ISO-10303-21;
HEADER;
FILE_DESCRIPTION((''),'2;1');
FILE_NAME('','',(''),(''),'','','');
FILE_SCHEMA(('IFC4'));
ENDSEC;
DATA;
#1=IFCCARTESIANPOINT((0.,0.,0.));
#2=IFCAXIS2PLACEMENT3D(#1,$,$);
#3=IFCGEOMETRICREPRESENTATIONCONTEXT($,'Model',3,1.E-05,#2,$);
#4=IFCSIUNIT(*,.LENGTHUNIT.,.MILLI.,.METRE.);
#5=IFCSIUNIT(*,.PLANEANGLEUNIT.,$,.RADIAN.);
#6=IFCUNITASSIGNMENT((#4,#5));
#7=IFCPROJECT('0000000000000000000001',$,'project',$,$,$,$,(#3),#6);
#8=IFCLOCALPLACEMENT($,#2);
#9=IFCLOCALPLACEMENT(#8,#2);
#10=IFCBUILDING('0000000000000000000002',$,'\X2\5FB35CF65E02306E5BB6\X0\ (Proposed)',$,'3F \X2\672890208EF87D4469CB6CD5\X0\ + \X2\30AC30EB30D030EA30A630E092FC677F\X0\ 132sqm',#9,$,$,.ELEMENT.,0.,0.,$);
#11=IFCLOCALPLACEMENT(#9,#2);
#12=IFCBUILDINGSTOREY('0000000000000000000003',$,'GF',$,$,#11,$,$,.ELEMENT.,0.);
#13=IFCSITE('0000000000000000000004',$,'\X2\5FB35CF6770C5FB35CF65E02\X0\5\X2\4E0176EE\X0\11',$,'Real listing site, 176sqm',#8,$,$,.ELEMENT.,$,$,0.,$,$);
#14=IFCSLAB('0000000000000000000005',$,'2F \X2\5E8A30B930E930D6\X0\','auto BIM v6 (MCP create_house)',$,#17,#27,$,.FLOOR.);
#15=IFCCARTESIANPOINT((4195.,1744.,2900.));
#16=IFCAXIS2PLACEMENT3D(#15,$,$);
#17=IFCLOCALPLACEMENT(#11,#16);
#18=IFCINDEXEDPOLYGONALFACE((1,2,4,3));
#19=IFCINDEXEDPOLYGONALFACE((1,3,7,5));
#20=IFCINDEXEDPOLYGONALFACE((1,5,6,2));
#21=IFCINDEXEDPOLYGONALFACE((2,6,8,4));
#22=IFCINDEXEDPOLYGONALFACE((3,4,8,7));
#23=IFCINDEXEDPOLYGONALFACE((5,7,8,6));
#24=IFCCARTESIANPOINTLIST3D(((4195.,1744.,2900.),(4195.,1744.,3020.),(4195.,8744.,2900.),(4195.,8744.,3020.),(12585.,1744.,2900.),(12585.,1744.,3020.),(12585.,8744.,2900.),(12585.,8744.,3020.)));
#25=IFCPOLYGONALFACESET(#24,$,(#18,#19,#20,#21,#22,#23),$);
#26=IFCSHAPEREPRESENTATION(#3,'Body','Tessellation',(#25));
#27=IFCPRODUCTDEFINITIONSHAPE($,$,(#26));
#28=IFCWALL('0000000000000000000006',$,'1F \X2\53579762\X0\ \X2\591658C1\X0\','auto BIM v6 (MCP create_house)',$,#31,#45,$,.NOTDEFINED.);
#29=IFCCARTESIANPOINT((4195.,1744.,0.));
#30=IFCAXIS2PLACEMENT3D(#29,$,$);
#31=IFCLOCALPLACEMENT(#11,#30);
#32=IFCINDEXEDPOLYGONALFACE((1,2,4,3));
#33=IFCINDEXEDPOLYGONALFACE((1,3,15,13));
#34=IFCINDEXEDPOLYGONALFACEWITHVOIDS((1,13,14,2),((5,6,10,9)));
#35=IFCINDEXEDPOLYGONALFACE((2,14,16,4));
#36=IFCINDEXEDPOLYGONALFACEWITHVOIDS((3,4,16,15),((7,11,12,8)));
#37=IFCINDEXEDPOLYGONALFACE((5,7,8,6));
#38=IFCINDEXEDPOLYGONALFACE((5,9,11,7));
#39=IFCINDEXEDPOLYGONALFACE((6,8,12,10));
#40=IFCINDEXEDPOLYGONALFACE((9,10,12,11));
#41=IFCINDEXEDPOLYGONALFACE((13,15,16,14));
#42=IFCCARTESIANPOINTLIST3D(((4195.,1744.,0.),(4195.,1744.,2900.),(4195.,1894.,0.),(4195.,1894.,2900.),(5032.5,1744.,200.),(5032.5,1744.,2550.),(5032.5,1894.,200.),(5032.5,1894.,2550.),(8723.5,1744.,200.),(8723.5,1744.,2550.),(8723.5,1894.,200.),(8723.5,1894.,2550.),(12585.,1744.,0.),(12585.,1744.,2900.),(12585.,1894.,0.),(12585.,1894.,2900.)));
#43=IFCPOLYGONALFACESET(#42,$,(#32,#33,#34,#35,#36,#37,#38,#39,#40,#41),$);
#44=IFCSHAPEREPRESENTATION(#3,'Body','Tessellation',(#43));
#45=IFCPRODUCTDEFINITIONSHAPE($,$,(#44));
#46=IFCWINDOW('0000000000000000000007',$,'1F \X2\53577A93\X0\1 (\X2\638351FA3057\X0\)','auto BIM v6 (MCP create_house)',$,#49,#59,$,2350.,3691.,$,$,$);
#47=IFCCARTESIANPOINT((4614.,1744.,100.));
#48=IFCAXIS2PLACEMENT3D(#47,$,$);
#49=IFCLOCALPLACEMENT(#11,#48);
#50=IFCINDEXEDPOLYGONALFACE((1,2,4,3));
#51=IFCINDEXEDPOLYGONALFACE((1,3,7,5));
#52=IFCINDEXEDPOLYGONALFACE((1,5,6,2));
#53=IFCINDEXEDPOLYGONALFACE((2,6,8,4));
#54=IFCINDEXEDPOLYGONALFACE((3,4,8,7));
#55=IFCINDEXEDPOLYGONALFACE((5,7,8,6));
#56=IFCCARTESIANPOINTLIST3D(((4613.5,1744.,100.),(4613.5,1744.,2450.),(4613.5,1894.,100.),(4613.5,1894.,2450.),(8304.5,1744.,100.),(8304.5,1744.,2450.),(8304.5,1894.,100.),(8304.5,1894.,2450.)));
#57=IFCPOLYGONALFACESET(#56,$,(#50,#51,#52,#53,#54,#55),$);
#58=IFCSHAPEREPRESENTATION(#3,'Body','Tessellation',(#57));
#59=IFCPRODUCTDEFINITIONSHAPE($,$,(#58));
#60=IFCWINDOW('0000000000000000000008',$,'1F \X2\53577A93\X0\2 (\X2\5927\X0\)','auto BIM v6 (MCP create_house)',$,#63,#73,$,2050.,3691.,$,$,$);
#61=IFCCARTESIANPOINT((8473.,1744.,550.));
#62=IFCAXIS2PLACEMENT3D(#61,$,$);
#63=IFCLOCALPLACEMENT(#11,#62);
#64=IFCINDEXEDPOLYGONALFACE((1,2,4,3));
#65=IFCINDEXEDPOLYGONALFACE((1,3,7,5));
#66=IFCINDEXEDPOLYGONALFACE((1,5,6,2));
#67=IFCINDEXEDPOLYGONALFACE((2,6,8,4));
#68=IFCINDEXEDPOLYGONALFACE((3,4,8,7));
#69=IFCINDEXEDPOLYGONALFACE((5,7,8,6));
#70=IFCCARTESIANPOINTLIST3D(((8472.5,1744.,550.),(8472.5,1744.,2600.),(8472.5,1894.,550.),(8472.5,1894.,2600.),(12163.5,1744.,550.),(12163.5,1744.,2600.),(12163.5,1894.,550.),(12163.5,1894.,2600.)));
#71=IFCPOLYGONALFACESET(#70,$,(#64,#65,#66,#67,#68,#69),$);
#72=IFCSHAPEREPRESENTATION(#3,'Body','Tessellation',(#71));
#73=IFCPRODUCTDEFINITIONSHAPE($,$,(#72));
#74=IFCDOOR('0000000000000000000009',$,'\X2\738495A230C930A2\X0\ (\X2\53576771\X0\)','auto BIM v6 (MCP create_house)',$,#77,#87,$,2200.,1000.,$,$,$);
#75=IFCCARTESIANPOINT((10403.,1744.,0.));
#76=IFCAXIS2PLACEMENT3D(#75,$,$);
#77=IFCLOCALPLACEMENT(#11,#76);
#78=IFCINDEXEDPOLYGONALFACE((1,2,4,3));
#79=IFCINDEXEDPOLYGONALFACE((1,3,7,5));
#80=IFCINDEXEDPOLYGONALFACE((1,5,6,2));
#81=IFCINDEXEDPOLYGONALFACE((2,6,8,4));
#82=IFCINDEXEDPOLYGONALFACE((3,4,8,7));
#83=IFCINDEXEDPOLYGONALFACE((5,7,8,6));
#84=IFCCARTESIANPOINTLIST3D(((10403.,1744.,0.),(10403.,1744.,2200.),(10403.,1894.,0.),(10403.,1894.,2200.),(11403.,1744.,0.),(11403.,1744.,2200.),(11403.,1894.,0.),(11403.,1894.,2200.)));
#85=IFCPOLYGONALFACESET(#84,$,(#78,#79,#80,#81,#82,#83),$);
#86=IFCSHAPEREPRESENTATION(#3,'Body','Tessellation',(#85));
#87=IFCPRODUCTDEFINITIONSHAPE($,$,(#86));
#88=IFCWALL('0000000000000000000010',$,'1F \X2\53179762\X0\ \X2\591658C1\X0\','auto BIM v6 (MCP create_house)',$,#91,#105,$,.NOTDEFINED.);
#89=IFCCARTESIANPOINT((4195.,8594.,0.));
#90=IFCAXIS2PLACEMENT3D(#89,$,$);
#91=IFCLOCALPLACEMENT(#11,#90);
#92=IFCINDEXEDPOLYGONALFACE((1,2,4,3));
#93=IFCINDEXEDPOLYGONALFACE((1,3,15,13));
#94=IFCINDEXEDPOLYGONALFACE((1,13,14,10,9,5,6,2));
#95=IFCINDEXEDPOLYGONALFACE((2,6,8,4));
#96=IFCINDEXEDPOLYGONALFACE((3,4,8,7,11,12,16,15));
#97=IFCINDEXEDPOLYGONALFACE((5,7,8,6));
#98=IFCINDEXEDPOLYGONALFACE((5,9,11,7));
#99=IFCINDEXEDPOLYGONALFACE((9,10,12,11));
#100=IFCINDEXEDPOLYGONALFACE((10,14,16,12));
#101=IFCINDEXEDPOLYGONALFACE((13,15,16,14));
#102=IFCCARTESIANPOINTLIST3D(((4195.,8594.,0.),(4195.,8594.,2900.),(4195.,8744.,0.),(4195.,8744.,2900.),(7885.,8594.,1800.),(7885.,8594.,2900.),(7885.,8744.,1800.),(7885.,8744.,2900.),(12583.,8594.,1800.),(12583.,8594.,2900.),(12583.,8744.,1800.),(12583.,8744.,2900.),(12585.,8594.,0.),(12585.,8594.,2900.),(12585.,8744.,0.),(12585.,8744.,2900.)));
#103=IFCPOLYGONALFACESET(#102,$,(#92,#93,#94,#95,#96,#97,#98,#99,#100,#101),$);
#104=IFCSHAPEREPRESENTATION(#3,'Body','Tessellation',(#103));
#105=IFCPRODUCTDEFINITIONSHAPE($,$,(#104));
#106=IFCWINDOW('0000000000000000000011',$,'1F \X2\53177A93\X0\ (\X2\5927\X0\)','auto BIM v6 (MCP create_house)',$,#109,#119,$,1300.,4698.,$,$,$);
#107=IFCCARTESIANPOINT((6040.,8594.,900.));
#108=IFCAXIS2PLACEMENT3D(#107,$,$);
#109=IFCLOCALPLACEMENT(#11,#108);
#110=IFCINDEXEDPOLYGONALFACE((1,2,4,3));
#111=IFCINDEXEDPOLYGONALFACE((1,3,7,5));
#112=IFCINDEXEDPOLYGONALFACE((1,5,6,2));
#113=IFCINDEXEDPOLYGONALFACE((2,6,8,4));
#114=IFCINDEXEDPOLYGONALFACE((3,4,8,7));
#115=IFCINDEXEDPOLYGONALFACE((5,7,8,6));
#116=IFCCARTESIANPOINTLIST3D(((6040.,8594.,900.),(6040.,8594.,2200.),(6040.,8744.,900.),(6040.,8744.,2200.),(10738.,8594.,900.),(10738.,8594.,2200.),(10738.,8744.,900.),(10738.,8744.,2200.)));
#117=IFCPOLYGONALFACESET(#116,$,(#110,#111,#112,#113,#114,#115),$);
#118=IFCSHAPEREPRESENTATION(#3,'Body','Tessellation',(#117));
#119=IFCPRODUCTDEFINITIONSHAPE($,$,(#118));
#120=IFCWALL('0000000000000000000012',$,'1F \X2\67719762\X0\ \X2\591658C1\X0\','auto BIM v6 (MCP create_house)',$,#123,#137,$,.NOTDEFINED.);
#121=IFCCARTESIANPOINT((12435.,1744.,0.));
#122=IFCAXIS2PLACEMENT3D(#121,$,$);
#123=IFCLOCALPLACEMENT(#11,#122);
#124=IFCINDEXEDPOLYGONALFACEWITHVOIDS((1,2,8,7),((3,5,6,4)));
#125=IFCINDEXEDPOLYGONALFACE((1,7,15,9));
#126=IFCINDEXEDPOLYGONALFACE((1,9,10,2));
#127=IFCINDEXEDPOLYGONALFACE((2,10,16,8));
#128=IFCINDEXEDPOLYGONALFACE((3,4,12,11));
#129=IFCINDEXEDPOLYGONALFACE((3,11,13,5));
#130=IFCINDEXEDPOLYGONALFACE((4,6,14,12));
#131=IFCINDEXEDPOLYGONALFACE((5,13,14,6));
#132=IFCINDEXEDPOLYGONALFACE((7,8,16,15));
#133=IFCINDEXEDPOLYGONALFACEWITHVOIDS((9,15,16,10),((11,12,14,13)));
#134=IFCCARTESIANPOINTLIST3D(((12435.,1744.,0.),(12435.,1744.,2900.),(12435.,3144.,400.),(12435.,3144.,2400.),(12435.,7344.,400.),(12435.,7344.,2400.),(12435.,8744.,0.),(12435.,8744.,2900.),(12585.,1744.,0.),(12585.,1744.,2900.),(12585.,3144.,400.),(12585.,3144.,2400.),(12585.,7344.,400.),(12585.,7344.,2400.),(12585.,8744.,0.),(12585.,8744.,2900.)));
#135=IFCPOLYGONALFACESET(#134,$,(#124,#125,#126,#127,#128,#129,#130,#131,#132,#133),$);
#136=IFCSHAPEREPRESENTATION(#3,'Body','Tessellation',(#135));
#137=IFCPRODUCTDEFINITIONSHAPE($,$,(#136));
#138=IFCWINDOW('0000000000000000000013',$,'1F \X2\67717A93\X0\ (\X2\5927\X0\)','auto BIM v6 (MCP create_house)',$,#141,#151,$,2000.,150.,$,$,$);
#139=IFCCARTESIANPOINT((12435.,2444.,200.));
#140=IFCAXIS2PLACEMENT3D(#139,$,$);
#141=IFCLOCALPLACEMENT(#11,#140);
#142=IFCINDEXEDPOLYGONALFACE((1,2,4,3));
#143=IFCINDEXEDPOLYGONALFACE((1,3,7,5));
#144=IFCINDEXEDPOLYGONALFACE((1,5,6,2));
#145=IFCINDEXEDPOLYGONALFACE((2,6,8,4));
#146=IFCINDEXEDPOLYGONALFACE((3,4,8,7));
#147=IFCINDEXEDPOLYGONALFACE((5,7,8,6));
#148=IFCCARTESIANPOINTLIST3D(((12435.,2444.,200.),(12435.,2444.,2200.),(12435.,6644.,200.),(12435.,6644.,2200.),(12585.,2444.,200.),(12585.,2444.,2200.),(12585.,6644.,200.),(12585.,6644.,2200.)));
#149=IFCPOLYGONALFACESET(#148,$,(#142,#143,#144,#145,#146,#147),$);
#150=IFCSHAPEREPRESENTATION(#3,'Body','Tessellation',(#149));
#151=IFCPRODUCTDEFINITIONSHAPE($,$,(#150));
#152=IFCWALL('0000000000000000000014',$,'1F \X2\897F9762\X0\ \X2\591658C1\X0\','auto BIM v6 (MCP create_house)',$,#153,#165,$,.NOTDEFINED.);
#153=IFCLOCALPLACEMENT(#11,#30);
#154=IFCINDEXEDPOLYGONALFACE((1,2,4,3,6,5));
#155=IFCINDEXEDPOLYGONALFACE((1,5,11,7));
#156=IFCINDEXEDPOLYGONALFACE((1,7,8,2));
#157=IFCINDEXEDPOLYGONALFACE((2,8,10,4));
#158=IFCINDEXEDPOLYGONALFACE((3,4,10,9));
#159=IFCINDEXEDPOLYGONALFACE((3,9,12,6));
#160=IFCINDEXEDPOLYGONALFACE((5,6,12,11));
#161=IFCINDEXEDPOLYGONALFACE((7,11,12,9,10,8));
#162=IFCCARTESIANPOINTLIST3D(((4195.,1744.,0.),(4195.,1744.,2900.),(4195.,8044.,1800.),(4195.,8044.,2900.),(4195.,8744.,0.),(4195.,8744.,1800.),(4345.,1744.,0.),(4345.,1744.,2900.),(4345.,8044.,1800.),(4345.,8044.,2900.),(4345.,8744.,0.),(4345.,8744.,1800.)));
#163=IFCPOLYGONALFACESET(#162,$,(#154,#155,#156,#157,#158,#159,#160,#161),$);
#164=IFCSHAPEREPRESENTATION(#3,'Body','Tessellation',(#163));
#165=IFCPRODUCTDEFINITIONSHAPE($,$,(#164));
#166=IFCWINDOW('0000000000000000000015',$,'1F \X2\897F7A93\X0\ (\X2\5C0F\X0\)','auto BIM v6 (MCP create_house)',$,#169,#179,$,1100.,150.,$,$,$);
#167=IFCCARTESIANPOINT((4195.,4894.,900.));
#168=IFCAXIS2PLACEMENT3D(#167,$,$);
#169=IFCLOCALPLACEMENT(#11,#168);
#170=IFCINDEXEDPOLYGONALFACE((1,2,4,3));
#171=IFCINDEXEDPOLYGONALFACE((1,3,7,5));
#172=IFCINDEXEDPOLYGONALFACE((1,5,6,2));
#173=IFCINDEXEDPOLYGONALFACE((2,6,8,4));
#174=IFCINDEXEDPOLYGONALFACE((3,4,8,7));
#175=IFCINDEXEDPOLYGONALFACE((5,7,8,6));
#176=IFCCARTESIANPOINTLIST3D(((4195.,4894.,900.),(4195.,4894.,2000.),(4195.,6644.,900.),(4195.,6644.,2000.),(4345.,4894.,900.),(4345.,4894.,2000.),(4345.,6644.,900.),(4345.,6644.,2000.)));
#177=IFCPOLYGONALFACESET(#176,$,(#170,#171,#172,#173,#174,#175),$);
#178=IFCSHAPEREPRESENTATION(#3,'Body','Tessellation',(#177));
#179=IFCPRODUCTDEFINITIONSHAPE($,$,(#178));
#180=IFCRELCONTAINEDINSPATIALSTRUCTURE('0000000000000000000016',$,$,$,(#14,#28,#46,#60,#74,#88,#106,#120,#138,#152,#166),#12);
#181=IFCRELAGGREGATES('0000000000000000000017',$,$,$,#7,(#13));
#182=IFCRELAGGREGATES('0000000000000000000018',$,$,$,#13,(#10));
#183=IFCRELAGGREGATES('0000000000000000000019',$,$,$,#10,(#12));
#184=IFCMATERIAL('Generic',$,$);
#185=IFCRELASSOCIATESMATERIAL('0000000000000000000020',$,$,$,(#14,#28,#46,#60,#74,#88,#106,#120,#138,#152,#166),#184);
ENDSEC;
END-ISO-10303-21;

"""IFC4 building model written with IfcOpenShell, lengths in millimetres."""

from ifc_helpers import new_model, si_unit, frame, frame_2d, origin, place, context, project, spatial, rectangle, extrude, material, element, fill, save


model = new_model("IFC4")

# Units and contexts
model_context = context("Model", 3, precision=1e-05, world=origin())
ifc_project = project(units=[si_unit("LENGTHUNIT", "METRE", prefix="MILLI"), si_unit("PLANEANGLEUNIT", "RADIAN")], contexts=[model_context])

# Site, building, storey
site_placement = place(None, origin())
site = spatial("IfcSite", under=ifc_project, at=site_placement, Name="徳島県徳島市5丁目11", ObjectType="Real listing site, 176sqm", CompositionType="ELEMENT", RefElevation=0.0)
building_placement = place(site_placement, origin())
building = spatial("IfcBuilding", under=site, at=building_placement, Name="徳島市の家 (Proposed)", ObjectType="3F 木造軸組構法 + ガルバリウム鋼板 132sqm", CompositionType="ELEMENT", ElevationOfRefHeight=0.0, ElevationOfTerrain=0.0)
storey_placement = place(building_placement, origin())
storey = spatial("IfcBuildingStorey", under=building, at=storey_placement, Name="GF", CompositionType="ELEMENT", Elevation=0.0)

# Slab
ifc_material = material(Name="Generic")
slab_1_placement = place(storey_placement, frame((4195.0, 1744.0, 2900.0)))
element("IfcSlab", 1, at=slab_1_placement, inside=storey, material=ifc_material, Name="2F 床スラブ", Description="auto BIM v6 (MCP create_house)", PredefinedType="FLOOR", context=model_context, shape_type="SweptSolid", body=[
    extrude(rectangle(XDim=8390.0, YDim=7000.0, at=frame_2d((4195.0, 3500.0))), frame((4195.0, 1744.0, 2900.0)), (0.0, 0.0, 1.0), 120.0),
])

# Wall, openings, windows, door
wall_1_placement = place(storey_placement, frame((4195.0, 1744.0, 0.0)))
wall_1 = element("IfcWall", 2, at=wall_1_placement, inside=storey, material=ifc_material, Name="1F 南面 外壁", Description="auto BIM v6 (MCP create_house)", PredefinedType="NOTDEFINED", context=model_context, shape_type="SweptSolid", body=[
    extrude(rectangle(XDim=8390.0, YDim=150.0, at=frame_2d((4195.0, 75.0))), frame((4195.0, 1744.0, 0.0)), (0.0, 0.0, 1.0), 2900.0),
])
opening_1_placement = place(storey_placement, frame((4614.0, 1744.0, 100.0)))
opening_1 = element("IfcOpeningElement", 3, at=opening_1_placement, cuts=wall_1, PredefinedType="NOTDEFINED", context=model_context, shape_type="SweptSolid", body=[
    extrude(rectangle(XDim=3691.0, YDim=150.0, at=frame_2d((1845.0, 75.0))), frame((4614.0, 1744.0, 100.0)), (0.0, 0.0, 1.0), 2350.0),
])
opening_2_placement = place(storey_placement, frame((8473.0, 1744.0, 550.0)))
opening_2 = element("IfcOpeningElement", 4, at=opening_2_placement, cuts=wall_1, PredefinedType="NOTDEFINED", context=model_context, shape_type="SweptSolid", body=[
    extrude(rectangle(XDim=3691.0, YDim=150.0, at=frame_2d((1845.0, 75.0))), frame((8473.0, 1744.0, 550.0)), (0.0, 0.0, 1.0), 2050.0),
])
opening_3_placement = place(storey_placement, frame((10403.0, 1744.0, 0.0)))
opening_3 = element("IfcOpeningElement", 5, at=opening_3_placement, cuts=wall_1, PredefinedType="NOTDEFINED", context=model_context, shape_type="SweptSolid", body=[
    extrude(rectangle(XDim=1000.0, YDim=150.0, at=frame_2d((500.0, 75.0))), frame((10403.0, 1744.0, 0.0)), (0.0, 0.0, 1.0), 2200.0),
])
window_1_placement = place(storey_placement, frame((4614.0, 1744.0, 100.0)))
window_1 = element("IfcWindow", 6, at=window_1_placement, inside=storey, material=ifc_material, Name="1F 南窓1 (掃出し)", Description="auto BIM v6 (MCP create_house)", OverallHeight=2350.0, OverallWidth=3691.0, context=model_context, shape_type="SweptSolid", body=[
    extrude(rectangle(XDim=3691.0, YDim=150.0, at=frame_2d((1845.0, 75.0))), frame((4614.0, 1744.0, 100.0)), (0.0, 0.0, 1.0), 2350.0),
])
fill(opening_1, window_1)
window_2_placement = place(storey_placement, frame((8473.0, 1744.0, 550.0)))
window_2 = element("IfcWindow", 7, at=window_2_placement, inside=storey, material=ifc_material, Name="1F 南窓2 (大)", Description="auto BIM v6 (MCP create_house)", OverallHeight=2050.0, OverallWidth=3691.0, context=model_context, shape_type="SweptSolid", body=[
    extrude(rectangle(XDim=3691.0, YDim=150.0, at=frame_2d((1845.0, 75.0))), frame((8473.0, 1744.0, 550.0)), (0.0, 0.0, 1.0), 2050.0),
])
fill(opening_2, window_2)
door_placement = place(storey_placement, frame((10403.0, 1744.0, 0.0)))
door = element("IfcDoor", 8, at=door_placement, inside=storey, material=ifc_material, Name="玄関ドア (南東)", Description="auto BIM v6 (MCP create_house)", OverallHeight=2200.0, OverallWidth=1000.0, context=model_context, shape_type="SweptSolid", body=[
    extrude(rectangle(XDim=1000.0, YDim=150.0, at=frame_2d((500.0, 75.0))), frame((10403.0, 1744.0, 0.0)), (0.0, 0.0, 1.0), 2200.0),
])
fill(opening_3, door)

# Walls, openings, windows
wall_2_placement = place(storey_placement, frame((4195.0, 8594.0, 0.0)))
wall_2 = element("IfcWall", 9, at=wall_2_placement, inside=storey, material=ifc_material, Name="1F 北面 外壁", Description="auto BIM v6 (MCP create_house)", PredefinedType="NOTDEFINED", context=model_context, shape_type="SweptSolid", body=[
    extrude(rectangle(XDim=8390.0, YDim=150.0, at=frame_2d((4195.0, 75.0))), frame((4195.0, 8594.0, 0.0)), (0.0, 0.0, 1.0), 2900.0),
])
opening_4_placement = place(storey_placement, frame((6040.0, 8594.0, 900.0)))
opening_4 = element("IfcOpeningElement", 10, at=opening_4_placement, cuts=wall_2, PredefinedType="NOTDEFINED", context=model_context, shape_type="SweptSolid", body=[
    extrude(rectangle(XDim=4698.0, YDim=150.0, at=frame_2d((2349.0, 75.0))), frame((6040.0, 8594.0, 900.0)), (0.0, 0.0, 1.0), 1300.0),
])
window_3_placement = place(storey_placement, frame((6040.0, 8594.0, 900.0)))
window_3 = element("IfcWindow", 11, at=window_3_placement, inside=storey, material=ifc_material, Name="1F 北窓 (大)", Description="auto BIM v6 (MCP create_house)", OverallHeight=1300.0, OverallWidth=4698.0, context=model_context, shape_type="SweptSolid", body=[
    extrude(rectangle(XDim=4698.0, YDim=150.0, at=frame_2d((2349.0, 75.0))), frame((6040.0, 8594.0, 900.0)), (0.0, 0.0, 1.0), 1300.0),
])
fill(opening_4, window_3)
wall_3_placement = place(storey_placement, frame((12435.0, 1744.0, 0.0)))
wall_3 = element("IfcWall", 12, at=wall_3_placement, inside=storey, material=ifc_material, Name="1F 東面 外壁", Description="auto BIM v6 (MCP create_house)", PredefinedType="NOTDEFINED", context=model_context, shape_type="SweptSolid", body=[
    extrude(rectangle(XDim=150.0, YDim=7000.0, at=frame_2d((75.0, 3500.0))), frame((12435.0, 1744.0, 0.0)), (0.0, 0.0, 1.0), 2900.0),
])
opening_5_placement = place(storey_placement, frame((12435.0, 2444.0, 200.0)))
opening_5 = element("IfcOpeningElement", 13, at=opening_5_placement, cuts=wall_3, PredefinedType="NOTDEFINED", context=model_context, shape_type="SweptSolid", body=[
    extrude(rectangle(XDim=150.0, YDim=4200.0, at=frame_2d((75.0, 2100.0))), frame((12435.0, 2444.0, 200.0)), (0.0, 0.0, 1.0), 2000.0),
])
window_4_placement = place(storey_placement, frame((12435.0, 2444.0, 200.0)))
window_4 = element("IfcWindow", 14, at=window_4_placement, inside=storey, material=ifc_material, Name="1F 東窓 (大)", Description="auto BIM v6 (MCP create_house)", OverallHeight=2000.0, OverallWidth=150.0, context=model_context, shape_type="SweptSolid", body=[
    extrude(rectangle(XDim=150.0, YDim=4200.0, at=frame_2d((75.0, 2100.0))), frame((12435.0, 2444.0, 200.0)), (0.0, 0.0, 1.0), 2000.0),
])
fill(opening_5, window_4)
wall_4_placement = place(storey_placement, frame((4195.0, 1744.0, 0.0)))
wall_4 = element("IfcWall", 15, at=wall_4_placement, inside=storey, material=ifc_material, Name="1F 西面 外壁", Description="auto BIM v6 (MCP create_house)", PredefinedType="NOTDEFINED", context=model_context, shape_type="SweptSolid", body=[
    extrude(rectangle(XDim=150.0, YDim=7000.0, at=frame_2d((75.0, 3500.0))), frame((4195.0, 1744.0, 0.0)), (0.0, 0.0, 1.0), 2900.0),
])
opening_6_placement = place(storey_placement, frame((4195.0, 4894.0, 900.0)))
opening_6 = element("IfcOpeningElement", 16, at=opening_6_placement, cuts=wall_4, PredefinedType="NOTDEFINED", context=model_context, shape_type="SweptSolid", body=[
    extrude(rectangle(XDim=150.0, YDim=1750.0, at=frame_2d((75.0, 875.0))), frame((4195.0, 4894.0, 900.0)), (0.0, 0.0, 1.0), 1100.0),
])
window_5_placement = place(storey_placement, frame((4195.0, 4894.0, 900.0)))
window_5 = element("IfcWindow", 17, at=window_5_placement, inside=storey, material=ifc_material, Name="1F 西窓 (小)", Description="auto BIM v6 (MCP create_house)", OverallHeight=1100.0, OverallWidth=150.0, context=model_context, shape_type="SweptSolid", body=[
    extrude(rectangle(XDim=150.0, YDim=1750.0, at=frame_2d((75.0, 875.0))), frame((4195.0, 4894.0, 900.0)), (0.0, 0.0, 1.0), 1100.0),
])
fill(opening_6, window_5)

save(model, "model.ifc")
